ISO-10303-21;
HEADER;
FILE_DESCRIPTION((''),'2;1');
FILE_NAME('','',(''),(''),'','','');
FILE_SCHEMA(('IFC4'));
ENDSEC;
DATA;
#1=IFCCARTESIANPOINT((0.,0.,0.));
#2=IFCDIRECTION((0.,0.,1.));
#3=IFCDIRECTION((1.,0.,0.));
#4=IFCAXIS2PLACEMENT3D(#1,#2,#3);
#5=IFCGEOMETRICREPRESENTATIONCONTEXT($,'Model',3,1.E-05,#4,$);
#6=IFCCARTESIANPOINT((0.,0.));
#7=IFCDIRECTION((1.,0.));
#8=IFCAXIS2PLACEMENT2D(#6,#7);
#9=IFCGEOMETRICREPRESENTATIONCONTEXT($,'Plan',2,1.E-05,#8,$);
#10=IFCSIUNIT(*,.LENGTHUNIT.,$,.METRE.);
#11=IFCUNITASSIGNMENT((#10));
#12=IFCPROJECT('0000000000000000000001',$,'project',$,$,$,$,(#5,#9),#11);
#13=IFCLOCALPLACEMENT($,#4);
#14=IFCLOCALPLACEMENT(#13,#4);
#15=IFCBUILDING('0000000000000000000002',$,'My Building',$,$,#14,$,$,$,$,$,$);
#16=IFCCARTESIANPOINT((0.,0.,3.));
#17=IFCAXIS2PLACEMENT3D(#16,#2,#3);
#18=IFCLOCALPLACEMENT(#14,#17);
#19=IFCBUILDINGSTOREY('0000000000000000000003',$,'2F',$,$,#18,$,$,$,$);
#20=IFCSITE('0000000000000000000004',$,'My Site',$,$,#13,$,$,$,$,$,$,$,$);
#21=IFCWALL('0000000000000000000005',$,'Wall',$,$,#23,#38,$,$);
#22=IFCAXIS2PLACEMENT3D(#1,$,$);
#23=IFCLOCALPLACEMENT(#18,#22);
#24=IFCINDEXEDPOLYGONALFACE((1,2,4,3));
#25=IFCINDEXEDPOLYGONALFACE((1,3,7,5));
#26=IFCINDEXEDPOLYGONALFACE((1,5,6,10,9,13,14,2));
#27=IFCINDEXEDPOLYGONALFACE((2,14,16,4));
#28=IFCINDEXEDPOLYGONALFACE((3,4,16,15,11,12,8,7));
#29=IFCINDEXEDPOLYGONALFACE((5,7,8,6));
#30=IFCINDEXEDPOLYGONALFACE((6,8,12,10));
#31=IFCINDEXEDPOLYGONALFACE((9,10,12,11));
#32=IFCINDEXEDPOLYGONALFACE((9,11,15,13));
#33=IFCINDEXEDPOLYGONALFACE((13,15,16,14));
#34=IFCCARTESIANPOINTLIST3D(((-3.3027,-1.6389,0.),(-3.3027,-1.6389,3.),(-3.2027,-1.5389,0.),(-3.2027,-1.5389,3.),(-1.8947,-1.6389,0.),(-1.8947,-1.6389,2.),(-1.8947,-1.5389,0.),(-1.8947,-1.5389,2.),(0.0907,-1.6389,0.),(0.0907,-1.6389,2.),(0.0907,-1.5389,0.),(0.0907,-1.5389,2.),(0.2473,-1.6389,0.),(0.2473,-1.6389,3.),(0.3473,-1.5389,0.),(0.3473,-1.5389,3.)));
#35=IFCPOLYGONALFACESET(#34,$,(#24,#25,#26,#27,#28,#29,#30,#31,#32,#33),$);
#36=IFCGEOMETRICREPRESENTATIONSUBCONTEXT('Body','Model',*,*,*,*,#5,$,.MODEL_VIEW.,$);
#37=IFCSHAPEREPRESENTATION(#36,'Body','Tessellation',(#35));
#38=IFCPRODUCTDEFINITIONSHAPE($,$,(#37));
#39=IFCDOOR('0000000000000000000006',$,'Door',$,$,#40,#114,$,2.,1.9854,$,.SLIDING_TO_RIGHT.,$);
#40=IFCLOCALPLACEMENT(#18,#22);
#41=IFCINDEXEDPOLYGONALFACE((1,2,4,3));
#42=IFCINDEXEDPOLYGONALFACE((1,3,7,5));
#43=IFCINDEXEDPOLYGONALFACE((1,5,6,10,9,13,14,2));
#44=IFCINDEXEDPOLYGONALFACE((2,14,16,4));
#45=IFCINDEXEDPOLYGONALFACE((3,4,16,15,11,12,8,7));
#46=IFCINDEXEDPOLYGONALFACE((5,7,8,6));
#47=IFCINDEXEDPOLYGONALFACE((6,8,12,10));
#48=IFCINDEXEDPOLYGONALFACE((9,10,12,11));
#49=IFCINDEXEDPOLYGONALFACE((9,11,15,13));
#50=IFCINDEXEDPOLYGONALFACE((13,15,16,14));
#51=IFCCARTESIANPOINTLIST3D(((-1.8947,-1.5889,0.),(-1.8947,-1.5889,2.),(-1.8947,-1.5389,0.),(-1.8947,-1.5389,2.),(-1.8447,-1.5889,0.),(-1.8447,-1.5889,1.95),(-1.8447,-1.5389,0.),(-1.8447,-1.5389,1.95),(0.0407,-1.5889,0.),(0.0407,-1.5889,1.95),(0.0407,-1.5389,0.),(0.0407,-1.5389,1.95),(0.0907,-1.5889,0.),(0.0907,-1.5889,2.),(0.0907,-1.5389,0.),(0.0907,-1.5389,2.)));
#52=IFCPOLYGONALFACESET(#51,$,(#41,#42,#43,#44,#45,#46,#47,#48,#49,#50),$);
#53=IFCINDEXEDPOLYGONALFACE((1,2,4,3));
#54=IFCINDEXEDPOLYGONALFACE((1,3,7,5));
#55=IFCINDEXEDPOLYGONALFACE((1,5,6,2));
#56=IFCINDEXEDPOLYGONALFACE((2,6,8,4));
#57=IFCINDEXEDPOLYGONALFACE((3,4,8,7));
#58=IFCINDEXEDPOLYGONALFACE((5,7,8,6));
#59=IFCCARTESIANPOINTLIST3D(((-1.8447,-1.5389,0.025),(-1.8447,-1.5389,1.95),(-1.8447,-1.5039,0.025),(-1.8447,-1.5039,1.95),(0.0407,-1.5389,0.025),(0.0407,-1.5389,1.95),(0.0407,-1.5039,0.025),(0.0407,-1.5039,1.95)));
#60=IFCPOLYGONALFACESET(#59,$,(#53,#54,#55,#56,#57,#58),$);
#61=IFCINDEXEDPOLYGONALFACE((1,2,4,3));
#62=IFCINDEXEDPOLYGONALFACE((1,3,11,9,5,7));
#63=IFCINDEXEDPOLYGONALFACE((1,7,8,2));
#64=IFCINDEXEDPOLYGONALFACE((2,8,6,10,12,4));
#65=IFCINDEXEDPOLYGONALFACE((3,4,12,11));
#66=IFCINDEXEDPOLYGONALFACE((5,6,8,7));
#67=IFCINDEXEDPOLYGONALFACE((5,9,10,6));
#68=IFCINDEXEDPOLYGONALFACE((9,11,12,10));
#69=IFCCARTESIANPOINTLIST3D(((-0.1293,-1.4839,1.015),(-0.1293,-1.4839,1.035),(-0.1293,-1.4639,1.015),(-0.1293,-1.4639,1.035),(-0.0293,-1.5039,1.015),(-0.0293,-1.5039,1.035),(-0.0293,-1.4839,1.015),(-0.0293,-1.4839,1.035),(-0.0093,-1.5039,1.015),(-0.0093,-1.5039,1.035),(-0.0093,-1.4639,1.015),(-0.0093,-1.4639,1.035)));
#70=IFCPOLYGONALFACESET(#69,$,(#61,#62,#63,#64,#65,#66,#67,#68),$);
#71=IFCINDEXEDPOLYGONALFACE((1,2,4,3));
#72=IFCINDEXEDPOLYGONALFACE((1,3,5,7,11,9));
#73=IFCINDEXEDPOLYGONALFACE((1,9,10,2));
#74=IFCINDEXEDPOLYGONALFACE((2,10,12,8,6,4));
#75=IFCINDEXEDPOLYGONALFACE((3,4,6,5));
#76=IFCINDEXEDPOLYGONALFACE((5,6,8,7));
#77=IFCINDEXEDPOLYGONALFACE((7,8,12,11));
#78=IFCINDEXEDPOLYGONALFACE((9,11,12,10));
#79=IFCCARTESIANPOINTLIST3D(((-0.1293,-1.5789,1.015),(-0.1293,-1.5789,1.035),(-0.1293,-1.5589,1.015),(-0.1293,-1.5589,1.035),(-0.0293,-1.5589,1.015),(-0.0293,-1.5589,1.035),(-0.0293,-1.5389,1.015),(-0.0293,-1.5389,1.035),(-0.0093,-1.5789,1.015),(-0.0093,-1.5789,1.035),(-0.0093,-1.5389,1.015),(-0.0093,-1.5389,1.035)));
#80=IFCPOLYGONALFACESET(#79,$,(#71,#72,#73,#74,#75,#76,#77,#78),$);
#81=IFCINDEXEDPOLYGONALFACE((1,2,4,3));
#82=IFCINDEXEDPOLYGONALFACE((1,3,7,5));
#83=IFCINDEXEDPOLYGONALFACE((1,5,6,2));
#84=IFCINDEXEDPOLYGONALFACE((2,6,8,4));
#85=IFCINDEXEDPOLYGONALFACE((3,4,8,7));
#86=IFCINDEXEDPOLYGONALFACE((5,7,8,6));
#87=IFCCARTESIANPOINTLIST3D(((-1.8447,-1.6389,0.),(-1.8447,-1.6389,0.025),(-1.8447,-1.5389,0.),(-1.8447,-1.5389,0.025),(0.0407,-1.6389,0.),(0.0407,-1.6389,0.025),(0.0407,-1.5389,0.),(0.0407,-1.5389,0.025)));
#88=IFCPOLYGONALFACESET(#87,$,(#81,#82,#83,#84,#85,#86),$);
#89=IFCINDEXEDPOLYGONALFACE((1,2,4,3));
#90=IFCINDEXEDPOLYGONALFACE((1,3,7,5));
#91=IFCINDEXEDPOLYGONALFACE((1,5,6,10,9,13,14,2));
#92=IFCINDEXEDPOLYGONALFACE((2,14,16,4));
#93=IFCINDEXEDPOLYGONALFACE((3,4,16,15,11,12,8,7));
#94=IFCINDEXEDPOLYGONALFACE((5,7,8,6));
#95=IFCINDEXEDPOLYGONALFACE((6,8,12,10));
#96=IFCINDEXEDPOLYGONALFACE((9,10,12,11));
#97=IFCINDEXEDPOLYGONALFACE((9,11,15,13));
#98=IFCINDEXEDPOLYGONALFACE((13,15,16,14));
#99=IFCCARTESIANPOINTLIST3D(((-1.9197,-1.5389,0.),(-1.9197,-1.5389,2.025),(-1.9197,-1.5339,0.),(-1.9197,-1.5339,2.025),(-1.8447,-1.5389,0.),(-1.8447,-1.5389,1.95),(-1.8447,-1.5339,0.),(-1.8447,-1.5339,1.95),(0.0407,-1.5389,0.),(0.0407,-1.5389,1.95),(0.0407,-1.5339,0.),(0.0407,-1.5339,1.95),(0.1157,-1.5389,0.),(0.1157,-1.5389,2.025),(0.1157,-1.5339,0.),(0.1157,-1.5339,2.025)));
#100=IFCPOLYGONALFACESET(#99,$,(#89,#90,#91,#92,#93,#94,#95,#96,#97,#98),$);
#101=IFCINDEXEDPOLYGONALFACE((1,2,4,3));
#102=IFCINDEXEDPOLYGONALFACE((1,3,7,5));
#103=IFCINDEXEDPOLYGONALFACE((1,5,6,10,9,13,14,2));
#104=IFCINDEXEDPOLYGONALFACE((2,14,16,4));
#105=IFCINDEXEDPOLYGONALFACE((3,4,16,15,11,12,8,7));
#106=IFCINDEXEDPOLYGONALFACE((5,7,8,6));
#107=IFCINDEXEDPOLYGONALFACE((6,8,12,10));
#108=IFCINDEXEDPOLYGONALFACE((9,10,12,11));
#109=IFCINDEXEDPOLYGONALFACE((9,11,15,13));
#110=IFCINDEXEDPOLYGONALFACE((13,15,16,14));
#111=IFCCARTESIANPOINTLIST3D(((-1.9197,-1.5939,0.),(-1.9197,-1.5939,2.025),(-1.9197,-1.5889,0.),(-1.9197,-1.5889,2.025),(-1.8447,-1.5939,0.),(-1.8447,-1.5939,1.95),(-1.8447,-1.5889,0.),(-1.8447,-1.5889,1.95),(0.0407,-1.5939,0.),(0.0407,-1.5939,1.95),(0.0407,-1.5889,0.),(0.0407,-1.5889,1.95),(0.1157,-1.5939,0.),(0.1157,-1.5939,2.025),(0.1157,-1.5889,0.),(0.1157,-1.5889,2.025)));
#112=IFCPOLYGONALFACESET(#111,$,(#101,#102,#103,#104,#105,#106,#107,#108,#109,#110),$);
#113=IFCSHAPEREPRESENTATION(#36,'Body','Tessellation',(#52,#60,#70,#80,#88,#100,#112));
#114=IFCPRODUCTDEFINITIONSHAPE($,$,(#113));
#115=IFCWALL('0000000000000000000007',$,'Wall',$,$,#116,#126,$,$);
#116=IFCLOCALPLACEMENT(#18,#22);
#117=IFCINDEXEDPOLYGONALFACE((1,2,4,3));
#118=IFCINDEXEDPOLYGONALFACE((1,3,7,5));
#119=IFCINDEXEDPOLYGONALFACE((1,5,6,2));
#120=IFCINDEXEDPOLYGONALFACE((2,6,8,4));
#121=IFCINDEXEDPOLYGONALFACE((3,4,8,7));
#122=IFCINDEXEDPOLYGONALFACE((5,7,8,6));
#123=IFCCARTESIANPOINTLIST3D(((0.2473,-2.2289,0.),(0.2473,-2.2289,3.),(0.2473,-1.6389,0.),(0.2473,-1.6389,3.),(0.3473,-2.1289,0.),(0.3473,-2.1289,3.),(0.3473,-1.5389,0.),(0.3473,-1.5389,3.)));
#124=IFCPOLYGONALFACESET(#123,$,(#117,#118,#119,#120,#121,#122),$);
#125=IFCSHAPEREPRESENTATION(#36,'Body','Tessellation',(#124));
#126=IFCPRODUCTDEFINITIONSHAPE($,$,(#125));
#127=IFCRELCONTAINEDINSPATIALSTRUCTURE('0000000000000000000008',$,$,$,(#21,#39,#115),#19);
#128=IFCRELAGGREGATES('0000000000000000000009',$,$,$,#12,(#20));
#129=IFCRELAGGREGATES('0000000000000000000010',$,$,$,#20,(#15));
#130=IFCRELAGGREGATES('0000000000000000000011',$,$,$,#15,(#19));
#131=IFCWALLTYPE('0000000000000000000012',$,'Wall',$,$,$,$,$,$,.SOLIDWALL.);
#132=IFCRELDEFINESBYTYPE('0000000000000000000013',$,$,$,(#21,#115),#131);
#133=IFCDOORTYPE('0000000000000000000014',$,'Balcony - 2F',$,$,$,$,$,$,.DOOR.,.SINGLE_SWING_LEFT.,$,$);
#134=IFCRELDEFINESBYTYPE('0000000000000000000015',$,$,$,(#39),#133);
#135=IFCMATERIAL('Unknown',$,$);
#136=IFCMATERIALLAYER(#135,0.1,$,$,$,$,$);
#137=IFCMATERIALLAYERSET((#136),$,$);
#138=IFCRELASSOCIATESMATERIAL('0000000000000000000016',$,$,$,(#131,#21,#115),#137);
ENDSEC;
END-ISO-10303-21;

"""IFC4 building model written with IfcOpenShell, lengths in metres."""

from ifc_helpers import new_model, entity, si_unit, frame, origin_with_axes, origin_2d_with_axis, place, context, subcontext, project, spatial, line, indexed_curve, outline, extrude, shape, source, transform, mapped, material, layer, layer_set, layer_usage, type_object, type_shapes, element, fill, save


model = new_model("IFC4")

# Units and contexts
model_context = context("Model", 3, precision=1e-05, world=origin_with_axes())
plan_context = context("Plan", 2, precision=1e-05, world=origin_2d_with_axis())
body_context_1 = subcontext(model_context, "Body", "Model", "MODEL_VIEW")
body_context_2 = subcontext(plan_context, "Body", "Plan", "PLAN_VIEW")
ifc_project = project(units=[si_unit("LENGTHUNIT", "METRE")], contexts=[model_context, plan_context])

# Site, building, storey
site_placement = place(None, origin_with_axes())
site = spatial("IfcSite", under=ifc_project, at=site_placement, Name="My Site")
building_placement = place(site_placement, origin_with_axes())
building = spatial("IfcBuilding", under=site, at=building_placement, Name="My Building")
storey_placement = place(building_placement, frame((0.0, 0.0, 3.0), z_axis=(0.0, 0.0, 1.0), x_axis=(1.0, 0.0, 0.0)))
storey = spatial("IfcBuildingStorey", under=building, at=storey_placement, Name="2F")

# Shared definitions
ifc_material = material(Name="Unknown")

# Shared definitions
ifc_layer = layer(ifc_material, 0.1)
ifc_layer_set = layer_set([ifc_layer])
wall_type = type_object("IfcWallType", Name="Wall", PredefinedType="SOLIDWALL", material=ifc_layer_set)

# Wall, opening, door
ifc_layer_usage_1 = layer_usage(ifc_layer_set, "AXIS2", "POSITIVE", 0.0)
wall_1_placement = place(storey_placement, frame((-3.3027, -1.6389, 0.0), z_axis=(0.0, 0.0, 1.0), x_axis=(1.0, 0.0, 0.0)))
wall_1 = element("IfcWall", 1, at=wall_1_placement, inside=storey, type_object=wall_type, material=ifc_layer_usage_1, Name="Wall", context=body_context_1, shape_type="SweptSolid", body=[
    extrude(outline(indexed_curve([(0.0, 0.0), (0.1, 0.1), (3.65, 0.1), (3.55, 0.0)], segments=[line(1, 2, 3, 4, 1)])), origin_with_axes(), (0.0, 0.0, 1.0), 3.0),
])
shared_shape_1 = source(origin_with_axes(), body_context_1, "Body", "SweptSolid", [
    extrude(outline(indexed_curve([(0.0, 0.0), (1.9854, 0.0), (1.9854, 2.0), (0.0, 2.0)], segments=[line(1, 2, 3, 4, 1)])), frame((0.0, -0.6, 0.0), z_axis=(0.0, -1.0, 0.0), x_axis=(1.0, 0.0, 0.0)), (0.0, 0.0, -1.0), 1.2),
])
opening_1_placement = place(wall_1_placement, frame((3.3934, 0.1, 0.0), z_axis=(0.0, 0.0, 1.0), x_axis=(-1.0, 0.0, 0.0)))
opening_1 = element("IfcOpeningElement", 2, at=opening_1_placement, cuts=wall_1, PredefinedType="OPENING", context=body_context_1, shape_type="MappedRepresentation", body=[
    mapped(shared_shape_1, transform((0.0, 0.0, 0.0), x_axis=(1.0, 0.0, 0.0), y_axis=(0.0, 1.0, 0.0), z_axis=(0.0, 0.0, 1.0), scale=1.0)),
])
door_type_1 = type_object("IfcDoorType", Name="Balcony - 2F", OperationType="SINGLE_SWING_LEFT", PredefinedType="DOOR")
shared_shape_2 = source(origin_with_axes(), body_context_1, "Body", "SweptSolid", [
    extrude(outline(indexed_curve([(0.0, 0.0), (0.0, 2.0), (1.9854, 2.0), (1.9854, 0.0), (1.9354, 0.0), (1.9354, 1.95), (0.05, 1.95), (0.05, 0.0)], segments=[line(1, 2, 3, 4, 5, 6, 7, 8, 1)])), frame((0.0, 0.0, 0.0), z_axis=(0.0, -1.0, 0.0), x_axis=(1.0, 0.0, 0.0)), (0.0, 0.0, -1.0), 0.05),
    extrude(outline(indexed_curve([(0.0, 0.0), (1.8854, 0.0), (1.8854, 0.035), (0.0, 0.035)], segments=[line(1, 2, 3, 4, 1)])), frame((0.05, -0.035, 0.025), z_axis=(0.0, 0.0, 1.0), x_axis=(1.0, 0.0, 0.0)), (0.0, 0.0, 1.0), 1.925),
    extrude(outline(indexed_curve([(0.0, 0.0), (0.0, -0.04), (0.12, -0.04), (0.12, -0.02), (0.02, -0.02), (0.02, 0.0)], segments=[line(1, 2, 3, 4, 5, 6, 1)])), frame((0.1, -0.035, 1.015), z_axis=(0.0, 0.0, 1.0), x_axis=(1.0, 0.0, 0.0)), (0.0, 0.0, 1.0), 0.02),
    extrude(outline(indexed_curve([(0.0, 0.0), (0.0, 0.04), (0.12, 0.04), (0.12, 0.02), (0.02, 0.02), (0.02, 0.0)], segments=[line(1, 2, 3, 4, 5, 6, 1)])), frame((0.1, 0.0, 1.015), z_axis=(0.0, 0.0, 1.0), x_axis=(1.0, 0.0, 0.0)), (0.0, 0.0, 1.0), 0.02),
    extrude(outline(indexed_curve([(0.0, 0.0), (1.8854, 0.0), (1.8854, 0.1), (0.0, 0.1)], segments=[line(1, 2, 3, 4, 1)])), frame((0.05, 0.0, 0.0), z_axis=(0.0, 0.0, 1.0), x_axis=(1.0, 0.0, 0.0)), (0.0, 0.0, 1.0), 0.025),
    extrude(outline(indexed_curve([(0.0, 0.0), (0.0, 2.025), (2.0354, 2.025), (2.0354, 0.0), (1.9604, 0.0), (1.9604, 1.95), (0.075, 1.95), (0.075, 0.0)], segments=[line(1, 2, 3, 4, 5, 6, 7, 8, 1)])), frame((-0.025, -0.005, 0.0), z_axis=(0.0, -1.0, 0.0), x_axis=(1.0, 0.0, 0.0)), (0.0, 0.0, -1.0), 0.005),
    extrude(outline(indexed_curve([(0.0, 0.0), (0.0, 2.025), (2.0354, 2.025), (2.0354, 0.0), (1.9604, 0.0), (1.9604, 1.95), (0.075, 1.95), (0.075, 0.0)], segments=[line(1, 2, 3, 4, 5, 6, 7, 8, 1)])), frame((-0.025, 0.05, 0.0), z_axis=(0.0, -1.0, 0.0), x_axis=(1.0, 0.0, 0.0)), (0.0, 0.0, -1.0), 0.005),
])
shared_shape_3 = source(origin_with_axes(), body_context_2, "Body", "Curve2D", [
    entity("IfcIndexedPolyCurve", entity("IfcCartesianPointList2D", [[0.0, 0.0], [0.05, 0.0], [0.05, 0.05], [0.0, 0.05]]), [entity("IfcLineIndex", [1, 2, 3, 4, 1])]),
    entity("IfcIndexedPolyCurve", entity("IfcCartesianPointList2D", [[1.9854, 0.0], [1.9354, 0.0], [1.9354, 0.05], [1.9854, 0.05]]), [entity("IfcLineIndex", [1, 2, 3, 4, 1])]),
    entity("IfcIndexedPolyCurve", entity("IfcCartesianPointList2D", [[2.8782, -0.035], [0.9927, -0.035], [0.9927, 0.0], [2.8782, 0.0]]), [entity("IfcLineIndex", [1, 2, 3, 4, 1])]),
])
type_shapes(door_type_1, [shared_shape_2, shared_shape_3])
door_1_placement = place(opening_1_placement, frame((0.0, 0.0, 0.0), z_axis=(0.0, 0.0, 1.0), x_axis=(1.0, 0.0, 0.0)))
door_1 = element("IfcDoor", 3, at=door_1_placement, inside=storey, type_object=door_type_1, Name="Door", OperationType="SLIDING_TO_RIGHT", OverallHeight=2.0, OverallWidth=1.9854, shapes=[
    shape(body_context_1, "Body", "MappedRepresentation", [mapped(shared_shape_2, transform((0.0, 0.0, 0.0), x_axis=(1.0, 0.0, 0.0), y_axis=(0.0, 1.0, 0.0), z_axis=(0.0, 0.0, 1.0), scale=1.0))]),
    shape(body_context_2, "Body", "MappedRepresentation", [mapped(shared_shape_3, transform((0.0, 0.0, 0.0), x_axis=(1.0, 0.0, 0.0), y_axis=(0.0, 1.0, 0.0), z_axis=(0.0, 0.0, 1.0), scale=1.0))]),
])
fill(opening_1, door_1)

# Wall
ifc_layer_usage_2 = layer_usage(ifc_layer_set, "AXIS2", "POSITIVE", 0.0)
wall_2_placement = place(storey_placement, frame((0.2473, -1.6389, 0.0), z_axis=(0.0, 0.0, 1.0), x_axis=(0.0, -1.0, 0.0)))
element("IfcWall", 4, at=wall_2_placement, inside=storey, type_object=wall_type, material=ifc_layer_usage_2, Name="Wall", context=body_context_1, shape_type="SweptSolid", body=[
    extrude(outline(indexed_curve([(0.0, 0.0), (-0.1, 0.1), (0.49, 0.1), (0.59, 0.0)], segments=[line(1, 2, 3, 4, 1)])), origin_with_axes(), (0.0, 0.0, 1.0), 3.0),
])

save(model, "model.ifc")
